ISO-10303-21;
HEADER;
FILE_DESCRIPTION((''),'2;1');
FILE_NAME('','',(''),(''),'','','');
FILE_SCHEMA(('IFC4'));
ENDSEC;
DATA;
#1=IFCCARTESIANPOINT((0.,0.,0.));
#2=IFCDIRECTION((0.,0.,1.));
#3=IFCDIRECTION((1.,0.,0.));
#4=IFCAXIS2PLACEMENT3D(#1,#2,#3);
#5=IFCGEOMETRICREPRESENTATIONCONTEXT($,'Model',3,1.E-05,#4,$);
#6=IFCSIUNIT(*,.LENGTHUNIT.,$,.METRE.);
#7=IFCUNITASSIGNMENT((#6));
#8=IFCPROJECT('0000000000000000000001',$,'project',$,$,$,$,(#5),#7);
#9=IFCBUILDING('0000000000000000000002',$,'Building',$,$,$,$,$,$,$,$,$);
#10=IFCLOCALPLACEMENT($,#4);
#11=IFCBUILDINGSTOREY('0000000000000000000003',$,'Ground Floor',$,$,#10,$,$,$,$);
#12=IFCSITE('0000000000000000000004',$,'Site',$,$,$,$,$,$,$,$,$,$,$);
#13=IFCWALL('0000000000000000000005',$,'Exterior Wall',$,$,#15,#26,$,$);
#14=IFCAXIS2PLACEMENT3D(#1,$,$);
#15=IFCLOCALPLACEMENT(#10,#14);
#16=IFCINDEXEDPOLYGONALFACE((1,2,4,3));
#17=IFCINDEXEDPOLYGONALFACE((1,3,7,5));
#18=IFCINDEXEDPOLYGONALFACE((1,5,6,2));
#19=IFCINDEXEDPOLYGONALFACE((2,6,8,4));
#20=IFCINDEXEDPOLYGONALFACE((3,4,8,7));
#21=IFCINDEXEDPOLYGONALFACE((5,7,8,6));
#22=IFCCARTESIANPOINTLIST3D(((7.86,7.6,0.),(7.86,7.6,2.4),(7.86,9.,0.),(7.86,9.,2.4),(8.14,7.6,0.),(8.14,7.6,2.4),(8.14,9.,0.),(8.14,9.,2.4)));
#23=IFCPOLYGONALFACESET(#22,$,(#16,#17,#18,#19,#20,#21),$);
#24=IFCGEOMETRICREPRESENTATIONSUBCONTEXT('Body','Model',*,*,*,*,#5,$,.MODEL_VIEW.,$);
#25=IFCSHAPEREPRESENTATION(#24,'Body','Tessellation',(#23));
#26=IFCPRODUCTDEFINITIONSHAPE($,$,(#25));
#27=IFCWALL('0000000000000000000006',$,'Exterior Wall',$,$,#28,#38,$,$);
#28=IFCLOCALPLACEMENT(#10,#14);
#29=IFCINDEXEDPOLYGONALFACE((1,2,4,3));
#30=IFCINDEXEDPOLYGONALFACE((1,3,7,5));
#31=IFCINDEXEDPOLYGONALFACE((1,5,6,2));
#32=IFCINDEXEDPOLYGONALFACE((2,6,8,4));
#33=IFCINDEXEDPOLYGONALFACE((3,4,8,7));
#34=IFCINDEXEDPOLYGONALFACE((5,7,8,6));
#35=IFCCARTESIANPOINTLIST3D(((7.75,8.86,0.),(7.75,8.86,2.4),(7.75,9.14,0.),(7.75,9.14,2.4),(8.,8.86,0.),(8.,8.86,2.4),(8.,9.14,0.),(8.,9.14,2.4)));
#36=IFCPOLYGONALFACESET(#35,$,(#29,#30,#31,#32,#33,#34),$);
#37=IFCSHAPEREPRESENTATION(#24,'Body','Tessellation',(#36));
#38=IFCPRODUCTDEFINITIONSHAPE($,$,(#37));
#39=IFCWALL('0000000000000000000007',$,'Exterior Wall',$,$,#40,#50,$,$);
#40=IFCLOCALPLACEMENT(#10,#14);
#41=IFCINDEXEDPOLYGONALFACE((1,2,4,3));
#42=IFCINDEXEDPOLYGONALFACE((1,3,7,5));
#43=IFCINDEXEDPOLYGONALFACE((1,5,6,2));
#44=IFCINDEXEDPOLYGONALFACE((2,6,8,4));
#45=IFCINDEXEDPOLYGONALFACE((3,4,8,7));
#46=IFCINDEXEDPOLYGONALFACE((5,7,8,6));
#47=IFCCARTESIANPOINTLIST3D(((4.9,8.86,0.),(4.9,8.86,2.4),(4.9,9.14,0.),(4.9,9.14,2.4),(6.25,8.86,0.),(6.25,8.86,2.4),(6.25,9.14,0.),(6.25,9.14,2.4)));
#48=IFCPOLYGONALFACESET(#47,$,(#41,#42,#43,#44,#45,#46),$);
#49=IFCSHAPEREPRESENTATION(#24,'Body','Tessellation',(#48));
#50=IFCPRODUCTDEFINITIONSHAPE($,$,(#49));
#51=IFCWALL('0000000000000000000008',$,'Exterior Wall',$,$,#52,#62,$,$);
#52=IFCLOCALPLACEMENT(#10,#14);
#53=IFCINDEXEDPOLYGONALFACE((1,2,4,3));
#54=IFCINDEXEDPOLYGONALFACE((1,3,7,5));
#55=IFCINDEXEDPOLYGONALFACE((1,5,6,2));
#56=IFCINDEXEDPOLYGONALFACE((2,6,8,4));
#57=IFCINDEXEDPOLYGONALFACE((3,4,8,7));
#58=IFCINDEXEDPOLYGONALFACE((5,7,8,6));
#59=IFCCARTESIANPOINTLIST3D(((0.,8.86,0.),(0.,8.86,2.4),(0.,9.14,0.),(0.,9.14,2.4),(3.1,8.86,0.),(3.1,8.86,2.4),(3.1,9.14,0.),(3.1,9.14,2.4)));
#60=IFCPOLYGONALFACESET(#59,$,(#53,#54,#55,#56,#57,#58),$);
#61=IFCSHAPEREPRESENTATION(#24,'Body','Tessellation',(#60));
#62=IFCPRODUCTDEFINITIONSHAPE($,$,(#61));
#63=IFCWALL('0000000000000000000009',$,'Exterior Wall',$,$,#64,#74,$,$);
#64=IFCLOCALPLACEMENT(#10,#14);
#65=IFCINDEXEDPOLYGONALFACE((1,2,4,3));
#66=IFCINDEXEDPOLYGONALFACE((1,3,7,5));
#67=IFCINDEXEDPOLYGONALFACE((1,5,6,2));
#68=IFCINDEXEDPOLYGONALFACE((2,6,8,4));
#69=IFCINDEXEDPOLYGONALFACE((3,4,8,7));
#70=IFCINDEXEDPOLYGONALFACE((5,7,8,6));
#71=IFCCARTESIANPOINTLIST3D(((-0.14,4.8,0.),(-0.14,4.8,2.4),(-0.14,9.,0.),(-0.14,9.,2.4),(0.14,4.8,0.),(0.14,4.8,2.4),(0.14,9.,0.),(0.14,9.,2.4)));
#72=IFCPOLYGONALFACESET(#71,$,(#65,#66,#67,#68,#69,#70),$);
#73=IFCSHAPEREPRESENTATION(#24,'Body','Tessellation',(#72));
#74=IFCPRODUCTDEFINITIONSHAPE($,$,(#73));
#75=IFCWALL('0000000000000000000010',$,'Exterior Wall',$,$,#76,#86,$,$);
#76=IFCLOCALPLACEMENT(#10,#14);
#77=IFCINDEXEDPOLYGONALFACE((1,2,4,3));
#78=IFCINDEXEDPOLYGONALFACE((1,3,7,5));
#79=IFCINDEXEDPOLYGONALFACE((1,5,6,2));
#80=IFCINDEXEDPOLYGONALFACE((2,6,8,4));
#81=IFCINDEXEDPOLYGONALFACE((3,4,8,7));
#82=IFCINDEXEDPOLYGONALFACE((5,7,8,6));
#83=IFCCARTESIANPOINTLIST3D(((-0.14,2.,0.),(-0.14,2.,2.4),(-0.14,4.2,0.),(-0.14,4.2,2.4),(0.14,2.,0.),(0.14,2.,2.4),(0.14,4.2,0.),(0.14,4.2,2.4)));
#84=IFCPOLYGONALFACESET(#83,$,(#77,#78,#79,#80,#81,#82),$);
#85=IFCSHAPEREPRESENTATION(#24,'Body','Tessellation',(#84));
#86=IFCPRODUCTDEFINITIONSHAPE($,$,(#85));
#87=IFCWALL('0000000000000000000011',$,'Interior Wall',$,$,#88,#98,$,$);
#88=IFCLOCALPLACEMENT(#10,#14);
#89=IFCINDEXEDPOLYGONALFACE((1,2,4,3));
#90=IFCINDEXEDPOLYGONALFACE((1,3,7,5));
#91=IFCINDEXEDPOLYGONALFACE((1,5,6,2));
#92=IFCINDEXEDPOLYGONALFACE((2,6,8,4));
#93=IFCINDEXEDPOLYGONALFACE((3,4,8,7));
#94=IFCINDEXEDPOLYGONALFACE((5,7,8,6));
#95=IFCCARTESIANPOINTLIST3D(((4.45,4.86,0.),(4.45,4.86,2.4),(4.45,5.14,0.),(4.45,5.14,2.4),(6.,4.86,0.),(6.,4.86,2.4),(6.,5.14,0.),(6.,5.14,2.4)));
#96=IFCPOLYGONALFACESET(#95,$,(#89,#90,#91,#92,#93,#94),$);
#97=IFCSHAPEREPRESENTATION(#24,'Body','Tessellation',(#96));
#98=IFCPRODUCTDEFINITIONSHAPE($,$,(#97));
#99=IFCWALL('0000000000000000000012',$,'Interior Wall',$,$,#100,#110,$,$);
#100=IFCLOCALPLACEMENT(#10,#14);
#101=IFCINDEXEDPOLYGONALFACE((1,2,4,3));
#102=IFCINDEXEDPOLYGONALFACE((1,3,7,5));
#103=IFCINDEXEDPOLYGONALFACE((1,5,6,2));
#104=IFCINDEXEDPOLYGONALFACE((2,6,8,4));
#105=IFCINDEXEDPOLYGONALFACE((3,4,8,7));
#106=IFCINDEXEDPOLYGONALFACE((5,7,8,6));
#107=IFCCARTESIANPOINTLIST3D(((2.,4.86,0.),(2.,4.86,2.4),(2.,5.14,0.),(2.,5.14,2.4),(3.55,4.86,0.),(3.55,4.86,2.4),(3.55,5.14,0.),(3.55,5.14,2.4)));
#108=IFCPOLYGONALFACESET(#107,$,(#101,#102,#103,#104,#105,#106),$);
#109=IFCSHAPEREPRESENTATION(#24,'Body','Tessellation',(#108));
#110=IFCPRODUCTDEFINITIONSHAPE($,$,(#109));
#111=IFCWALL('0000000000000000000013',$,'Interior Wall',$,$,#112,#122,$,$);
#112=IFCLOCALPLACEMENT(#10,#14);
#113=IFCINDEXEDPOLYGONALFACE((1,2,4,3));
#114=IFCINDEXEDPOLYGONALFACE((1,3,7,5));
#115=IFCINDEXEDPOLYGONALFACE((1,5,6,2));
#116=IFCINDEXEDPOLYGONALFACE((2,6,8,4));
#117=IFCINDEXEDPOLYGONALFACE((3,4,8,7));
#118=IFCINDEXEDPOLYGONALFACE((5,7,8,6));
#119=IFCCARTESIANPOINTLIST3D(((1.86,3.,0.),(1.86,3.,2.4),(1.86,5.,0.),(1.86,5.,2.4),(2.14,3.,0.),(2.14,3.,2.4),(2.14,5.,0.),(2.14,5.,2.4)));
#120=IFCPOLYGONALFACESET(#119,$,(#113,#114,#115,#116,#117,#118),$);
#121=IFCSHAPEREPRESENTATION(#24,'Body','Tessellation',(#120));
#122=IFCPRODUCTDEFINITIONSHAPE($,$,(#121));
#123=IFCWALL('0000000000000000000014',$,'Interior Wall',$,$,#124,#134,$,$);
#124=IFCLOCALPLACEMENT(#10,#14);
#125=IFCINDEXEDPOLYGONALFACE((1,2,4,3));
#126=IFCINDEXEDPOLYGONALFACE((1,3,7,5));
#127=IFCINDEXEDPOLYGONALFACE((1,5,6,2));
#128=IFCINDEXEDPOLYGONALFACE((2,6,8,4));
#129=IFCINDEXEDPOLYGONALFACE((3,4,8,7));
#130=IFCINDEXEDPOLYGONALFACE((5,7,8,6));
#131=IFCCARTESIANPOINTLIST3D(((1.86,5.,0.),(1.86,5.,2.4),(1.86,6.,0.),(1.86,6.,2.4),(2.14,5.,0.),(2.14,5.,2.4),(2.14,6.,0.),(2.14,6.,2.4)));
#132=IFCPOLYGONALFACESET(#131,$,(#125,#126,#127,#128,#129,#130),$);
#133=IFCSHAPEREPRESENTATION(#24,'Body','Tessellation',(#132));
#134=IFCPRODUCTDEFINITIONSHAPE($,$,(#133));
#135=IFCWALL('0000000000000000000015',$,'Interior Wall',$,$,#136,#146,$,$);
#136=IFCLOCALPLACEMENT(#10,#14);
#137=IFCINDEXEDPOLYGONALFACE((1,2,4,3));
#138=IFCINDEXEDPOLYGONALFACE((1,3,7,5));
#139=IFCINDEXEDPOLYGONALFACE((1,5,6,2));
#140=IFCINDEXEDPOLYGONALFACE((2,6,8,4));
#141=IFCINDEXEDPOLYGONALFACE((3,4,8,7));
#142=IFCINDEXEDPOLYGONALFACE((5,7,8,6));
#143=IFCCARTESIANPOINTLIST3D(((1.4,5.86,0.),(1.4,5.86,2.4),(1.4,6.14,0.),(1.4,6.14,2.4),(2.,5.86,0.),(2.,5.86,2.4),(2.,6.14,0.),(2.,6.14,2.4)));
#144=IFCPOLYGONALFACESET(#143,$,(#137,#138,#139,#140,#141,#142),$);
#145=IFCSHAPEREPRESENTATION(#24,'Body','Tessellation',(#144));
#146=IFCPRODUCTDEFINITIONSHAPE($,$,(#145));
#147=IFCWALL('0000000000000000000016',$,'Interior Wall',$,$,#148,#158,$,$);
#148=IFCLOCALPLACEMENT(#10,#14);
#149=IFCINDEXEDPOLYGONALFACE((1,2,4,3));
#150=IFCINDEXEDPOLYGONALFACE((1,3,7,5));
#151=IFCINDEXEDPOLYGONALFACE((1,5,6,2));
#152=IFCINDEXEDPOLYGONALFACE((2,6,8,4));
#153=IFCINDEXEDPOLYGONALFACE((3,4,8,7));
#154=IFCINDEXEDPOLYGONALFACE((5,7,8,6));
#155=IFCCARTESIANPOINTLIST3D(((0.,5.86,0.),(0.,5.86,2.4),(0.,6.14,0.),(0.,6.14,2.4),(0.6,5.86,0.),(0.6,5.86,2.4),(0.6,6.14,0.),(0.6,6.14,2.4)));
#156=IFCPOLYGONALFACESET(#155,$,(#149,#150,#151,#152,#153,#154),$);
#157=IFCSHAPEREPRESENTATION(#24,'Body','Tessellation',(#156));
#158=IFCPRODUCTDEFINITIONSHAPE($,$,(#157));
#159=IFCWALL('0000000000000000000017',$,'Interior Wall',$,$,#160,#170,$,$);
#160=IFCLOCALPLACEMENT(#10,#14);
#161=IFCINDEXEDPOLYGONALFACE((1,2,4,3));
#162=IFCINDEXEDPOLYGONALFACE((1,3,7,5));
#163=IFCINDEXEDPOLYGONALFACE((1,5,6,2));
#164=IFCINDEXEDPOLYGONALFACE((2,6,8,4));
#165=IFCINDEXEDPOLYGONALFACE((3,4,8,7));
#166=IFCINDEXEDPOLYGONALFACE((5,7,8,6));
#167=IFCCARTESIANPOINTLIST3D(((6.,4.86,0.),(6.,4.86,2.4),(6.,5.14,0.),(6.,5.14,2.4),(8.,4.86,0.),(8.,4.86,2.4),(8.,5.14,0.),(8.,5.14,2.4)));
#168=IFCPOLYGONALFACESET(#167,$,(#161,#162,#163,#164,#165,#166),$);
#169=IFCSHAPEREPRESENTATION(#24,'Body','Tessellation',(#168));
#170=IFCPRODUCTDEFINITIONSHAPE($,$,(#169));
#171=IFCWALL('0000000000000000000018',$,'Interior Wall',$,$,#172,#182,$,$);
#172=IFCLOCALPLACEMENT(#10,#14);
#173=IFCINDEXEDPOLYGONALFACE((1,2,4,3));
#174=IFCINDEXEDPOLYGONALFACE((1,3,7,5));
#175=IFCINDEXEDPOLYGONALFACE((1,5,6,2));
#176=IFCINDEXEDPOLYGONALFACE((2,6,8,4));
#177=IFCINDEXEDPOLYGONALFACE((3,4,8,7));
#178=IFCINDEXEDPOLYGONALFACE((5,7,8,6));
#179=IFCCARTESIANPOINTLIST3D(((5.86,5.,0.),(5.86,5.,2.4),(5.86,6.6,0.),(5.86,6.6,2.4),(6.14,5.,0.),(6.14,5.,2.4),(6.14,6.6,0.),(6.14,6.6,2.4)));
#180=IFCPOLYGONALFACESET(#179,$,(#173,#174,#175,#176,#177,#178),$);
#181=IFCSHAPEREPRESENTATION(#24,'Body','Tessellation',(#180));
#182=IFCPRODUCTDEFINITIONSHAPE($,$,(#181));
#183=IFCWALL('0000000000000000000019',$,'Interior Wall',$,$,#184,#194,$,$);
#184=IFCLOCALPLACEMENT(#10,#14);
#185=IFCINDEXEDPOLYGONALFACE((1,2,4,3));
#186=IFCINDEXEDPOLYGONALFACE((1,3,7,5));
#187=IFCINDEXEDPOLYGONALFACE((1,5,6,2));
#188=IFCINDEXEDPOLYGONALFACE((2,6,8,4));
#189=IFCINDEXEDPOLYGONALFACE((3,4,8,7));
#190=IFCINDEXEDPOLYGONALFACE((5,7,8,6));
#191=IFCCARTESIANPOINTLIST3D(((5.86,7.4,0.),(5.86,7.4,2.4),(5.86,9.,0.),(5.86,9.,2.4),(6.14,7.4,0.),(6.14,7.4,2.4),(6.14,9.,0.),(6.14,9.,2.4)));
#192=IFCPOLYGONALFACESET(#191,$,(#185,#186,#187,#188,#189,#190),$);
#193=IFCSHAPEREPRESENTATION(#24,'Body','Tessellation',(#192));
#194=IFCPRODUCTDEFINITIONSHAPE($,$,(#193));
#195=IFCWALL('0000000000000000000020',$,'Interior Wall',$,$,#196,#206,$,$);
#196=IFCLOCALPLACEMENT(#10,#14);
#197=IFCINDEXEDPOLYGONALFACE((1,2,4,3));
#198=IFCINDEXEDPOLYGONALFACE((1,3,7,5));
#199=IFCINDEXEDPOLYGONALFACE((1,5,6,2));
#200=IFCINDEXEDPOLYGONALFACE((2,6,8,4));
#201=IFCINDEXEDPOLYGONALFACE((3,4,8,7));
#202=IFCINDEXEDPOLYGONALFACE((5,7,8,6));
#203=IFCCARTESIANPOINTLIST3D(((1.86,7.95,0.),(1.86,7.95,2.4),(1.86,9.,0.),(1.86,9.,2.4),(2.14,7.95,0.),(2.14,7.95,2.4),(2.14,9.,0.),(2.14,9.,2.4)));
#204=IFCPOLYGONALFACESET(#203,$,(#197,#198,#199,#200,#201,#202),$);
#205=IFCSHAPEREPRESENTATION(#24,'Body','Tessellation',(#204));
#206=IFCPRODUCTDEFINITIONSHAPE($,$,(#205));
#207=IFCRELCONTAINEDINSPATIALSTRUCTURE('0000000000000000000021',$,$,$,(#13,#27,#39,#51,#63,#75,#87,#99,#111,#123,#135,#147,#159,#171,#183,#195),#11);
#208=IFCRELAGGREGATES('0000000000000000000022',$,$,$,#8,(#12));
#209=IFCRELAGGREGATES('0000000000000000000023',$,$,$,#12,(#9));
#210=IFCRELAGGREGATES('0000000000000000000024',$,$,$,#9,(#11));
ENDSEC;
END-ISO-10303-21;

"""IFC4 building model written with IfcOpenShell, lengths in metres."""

from ifc_helpers import new_model, si_unit, frame, origin_with_axes, place, context, subcontext, project, spatial, indexed_curve, outline, extrude, element, save


model = new_model("IFC4")

# Units and contexts
model_context = context("Model", 3, precision=1e-05, world=origin_with_axes())
body_context = subcontext(model_context, "Body", "Model", "MODEL_VIEW")
ifc_project = project(units=[si_unit("LENGTHUNIT", "METRE")], contexts=[model_context])

# Site, building, storey
site = spatial("IfcSite", under=ifc_project, Name="Site")
building = spatial("IfcBuilding", under=site, Name="Building")
storey_placement = place(None, origin_with_axes())
storey = spatial("IfcBuildingStorey", under=building, at=storey_placement, Name="Ground Floor")

# Walls
wall_1_placement = place(storey_placement, frame((8.0, 7.6, 0.0), z_axis=(0.0, 0.0, 1.0), x_axis=(0.0, 1.0, 0.0)))
element("IfcWall", 1, at=wall_1_placement, inside=storey, Name="Exterior Wall", context=body_context, shape_type="SweptSolid", body=[
    extrude(outline(indexed_curve([(0.0, 0.0), (0.0, 0.28), (1.4, 0.28), (1.4, 0.0), (0.0, 0.0)], self_intersect=False)), frame((0.0, -0.14, 0.0), z_axis=(0.0, 0.0, 1.0), x_axis=(1.0, 0.0, 0.0)), (0.0, 0.0, 1.0), 2.4),
])
wall_2_placement = place(storey_placement, frame((8.0, 9.0, 0.0), z_axis=(0.0, 0.0, 1.0), x_axis=(-1.0, 0.0, 0.0)))
element("IfcWall", 2, at=wall_2_placement, inside=storey, Name="Exterior Wall", context=body_context, shape_type="SweptSolid", body=[
    extrude(outline(indexed_curve([(0.0, 0.0), (0.0, 0.28), (0.25, 0.28), (0.25, 0.0), (0.0, 0.0)], self_intersect=False)), frame((0.0, -0.14, 0.0), z_axis=(0.0, 0.0, 1.0), x_axis=(1.0, 0.0, 0.0)), (0.0, 0.0, 1.0), 2.4),
])
wall_3_placement = place(storey_placement, frame((6.25, 9.0, 0.0), z_axis=(0.0, 0.0, 1.0), x_axis=(-1.0, 0.0, 0.0)))
element("IfcWall", 3, at=wall_3_placement, inside=storey, Name="Exterior Wall", context=body_context, shape_type="SweptSolid", body=[
    extrude(outline(indexed_curve([(0.0, 0.0), (0.0, 0.28), (1.35, 0.28), (1.35, 0.0), (0.0, 0.0)], self_intersect=False)), frame((0.0, -0.14, 0.0), z_axis=(0.0, 0.0, 1.0), x_axis=(1.0, 0.0, 0.0)), (0.0, 0.0, 1.0), 2.4),
])
wall_4_placement = place(storey_placement, frame((3.1, 9.0, 0.0), z_axis=(0.0, 0.0, 1.0), x_axis=(-1.0, 0.0, 0.0)))
element("IfcWall", 4, at=wall_4_placement, inside=storey, Name="Exterior Wall", context=body_context, shape_type="SweptSolid", body=[
    extrude(outline(indexed_curve([(0.0, 0.0), (0.0, 0.28), (3.1, 0.28), (3.1, 0.0), (0.0, 0.0)], self_intersect=False)), frame((0.0, -0.14, 0.0), z_axis=(0.0, 0.0, 1.0), x_axis=(1.0, 0.0, 0.0)), (0.0, 0.0, 1.0), 2.4),
])
wall_5_placement = place(storey_placement, frame((0.0, 9.0, 0.0), z_axis=(0.0, 0.0, 1.0), x_axis=(0.0, -1.0, 0.0)))
element("IfcWall", 5, at=wall_5_placement, inside=storey, Name="Exterior Wall", context=body_context, shape_type="SweptSolid", body=[
    extrude(outline(indexed_curve([(0.0, 0.0), (0.0, 0.28), (4.2, 0.28), (4.2, 0.0), (0.0, 0.0)], self_intersect=False)), frame((0.0, -0.14, 0.0), z_axis=(0.0, 0.0, 1.0), x_axis=(1.0, 0.0, 0.0)), (0.0, 0.0, 1.0), 2.4),
])
wall_6_placement = place(storey_placement, frame((0.0, 4.2, 0.0), z_axis=(0.0, 0.0, 1.0), x_axis=(0.0, -1.0, 0.0)))
element("IfcWall", 6, at=wall_6_placement, inside=storey, Name="Exterior Wall", context=body_context, shape_type="SweptSolid", body=[
    extrude(outline(indexed_curve([(0.0, 0.0), (0.0, 0.28), (2.2, 0.28), (2.2, 0.0), (0.0, 0.0)], self_intersect=False)), frame((0.0, -0.14, 0.0), z_axis=(0.0, 0.0, 1.0), x_axis=(1.0, 0.0, 0.0)), (0.0, 0.0, 1.0), 2.4),
])
for number, where, z_axis, x_axis, name in (
    (7, (6.0, 5.0, 0.0), (0.0, 0.0, 1.0), (-1.0, 0.0, 0.0), "Interior Wall"),
    (8, (3.55, 5.0, 0.0), (0.0, 0.0, 1.0), (-1.0, 0.0, 0.0), "Interior Wall"),
):
    element("IfcWall", number, at=place(storey_placement, frame(where, z_axis=z_axis, x_axis=x_axis)), inside=storey, Name=name, context=body_context, shape_type="SweptSolid", body=[
        extrude(outline(indexed_curve([(0.0, 0.0), (0.0, 0.28), (1.55, 0.28), (1.55, 0.0), (0.0, 0.0)], self_intersect=False)), frame((0.0, -0.14, 0.0), z_axis=(0.0, 0.0, 1.0), x_axis=(1.0, 0.0, 0.0)), (0.0, 0.0, 1.0), 2.4),
    ])
wall_7_placement = place(storey_placement, frame((2.0, 5.0, 0.0), z_axis=(0.0, 0.0, 1.0), x_axis=(0.0, -1.0, 0.0)))
element("IfcWall", 9, at=wall_7_placement, inside=storey, Name="Interior Wall", context=body_context, shape_type="SweptSolid", body=[
    extrude(outline(indexed_curve([(0.0, 0.0), (0.0, 0.28), (2.0, 0.28), (2.0, 0.0), (0.0, 0.0)], self_intersect=False)), frame((0.0, -0.14, 0.0), z_axis=(0.0, 0.0, 1.0), x_axis=(1.0, 0.0, 0.0)), (0.0, 0.0, 1.0), 2.4),
])
wall_8_placement = place(storey_placement, frame((2.0, 5.0, 0.0), z_axis=(0.0, 0.0, 1.0), x_axis=(0.0, 1.0, 0.0)))
element("IfcWall", 10, at=wall_8_placement, inside=storey, Name="Interior Wall", context=body_context, shape_type="SweptSolid", body=[
    extrude(outline(indexed_curve([(0.0, 0.0), (0.0, 0.28), (1.0, 0.28), (1.0, 0.0), (0.0, 0.0)], self_intersect=False)), frame((0.0, -0.14, 0.0), z_axis=(0.0, 0.0, 1.0), x_axis=(1.0, 0.0, 0.0)), (0.0, 0.0, 1.0), 2.4),
])
for number, where, z_axis, x_axis, name in (
    (11, (2.0, 6.0, 0.0), (0.0, 0.0, 1.0), (-1.0, 0.0, 0.0), "Interior Wall"),
    (12, (0.6, 6.0, 0.0), (0.0, 0.0, 1.0), (-1.0, 0.0, 0.0), "Interior Wall"),
):
    element("IfcWall", number, at=place(storey_placement, frame(where, z_axis=z_axis, x_axis=x_axis)), inside=storey, Name=name, context=body_context, shape_type="SweptSolid", body=[
        extrude(outline(indexed_curve([(0.0, 0.0), (0.0, 0.28), (0.6, 0.28), (0.6, 0.0), (0.0, 0.0)], self_intersect=False)), frame((0.0, -0.14, 0.0), z_axis=(0.0, 0.0, 1.0), x_axis=(1.0, 0.0, 0.0)), (0.0, 0.0, 1.0), 2.4),
    ])
wall_9_placement = place(storey_placement, frame((8.0, 5.0, 0.0), z_axis=(0.0, 0.0, 1.0), x_axis=(-1.0, 0.0, 0.0)))
element("IfcWall", 13, at=wall_9_placement, inside=storey, Name="Interior Wall", context=body_context, shape_type="SweptSolid", body=[
    extrude(outline(indexed_curve([(0.0, 0.0), (0.0, 0.28), (2.0, 0.28), (2.0, 0.0), (0.0, 0.0)], self_intersect=False)), frame((0.0, -0.14, 0.0), z_axis=(0.0, 0.0, 1.0), x_axis=(1.0, 0.0, 0.0)), (0.0, 0.0, 1.0), 2.4),
])
for number, where, z_axis, x_axis, name in (
    (14, (6.0, 5.0, 0.0), (0.0, 0.0, 1.0), (0.0, 1.0, 0.0), "Interior Wall"),
    (15, (6.0, 7.4, 0.0), (0.0, 0.0, 1.0), (0.0, 1.0, 0.0), "Interior Wall"),
):
    element("IfcWall", number, at=place(storey_placement, frame(where, z_axis=z_axis, x_axis=x_axis)), inside=storey, Name=name, context=body_context, shape_type="SweptSolid", body=[
        extrude(outline(indexed_curve([(0.0, 0.0), (0.0, 0.28), (1.6, 0.28), (1.6, 0.0), (0.0, 0.0)], self_intersect=False)), frame((0.0, -0.14, 0.0), z_axis=(0.0, 0.0, 1.0), x_axis=(1.0, 0.0, 0.0)), (0.0, 0.0, 1.0), 2.4),
    ])
for number, where, z_axis, x_axis, name in (
    (16, (2.0, 9.0, 0.0), (0.0, 0.0, 1.0), (0.0, -1.0, 0.0), "Interior Wall"),
):
    element("IfcWall", number, at=place(storey_placement, frame(where, z_axis=z_axis, x_axis=x_axis)), inside=storey, Name=name, context=body_context, shape_type="SweptSolid", body=[
        extrude(outline(indexed_curve([(0.0, 0.0), (0.0, 0.28), (1.05, 0.28), (1.05, 0.0), (0.0, 0.0)], self_intersect=False)), frame((0.0, -0.14, 0.0), z_axis=(0.0, 0.0, 1.0), x_axis=(1.0, 0.0, 0.0)), (0.0, 0.0, 1.0), 2.4),
    ])

save(model, "model.ifc")
